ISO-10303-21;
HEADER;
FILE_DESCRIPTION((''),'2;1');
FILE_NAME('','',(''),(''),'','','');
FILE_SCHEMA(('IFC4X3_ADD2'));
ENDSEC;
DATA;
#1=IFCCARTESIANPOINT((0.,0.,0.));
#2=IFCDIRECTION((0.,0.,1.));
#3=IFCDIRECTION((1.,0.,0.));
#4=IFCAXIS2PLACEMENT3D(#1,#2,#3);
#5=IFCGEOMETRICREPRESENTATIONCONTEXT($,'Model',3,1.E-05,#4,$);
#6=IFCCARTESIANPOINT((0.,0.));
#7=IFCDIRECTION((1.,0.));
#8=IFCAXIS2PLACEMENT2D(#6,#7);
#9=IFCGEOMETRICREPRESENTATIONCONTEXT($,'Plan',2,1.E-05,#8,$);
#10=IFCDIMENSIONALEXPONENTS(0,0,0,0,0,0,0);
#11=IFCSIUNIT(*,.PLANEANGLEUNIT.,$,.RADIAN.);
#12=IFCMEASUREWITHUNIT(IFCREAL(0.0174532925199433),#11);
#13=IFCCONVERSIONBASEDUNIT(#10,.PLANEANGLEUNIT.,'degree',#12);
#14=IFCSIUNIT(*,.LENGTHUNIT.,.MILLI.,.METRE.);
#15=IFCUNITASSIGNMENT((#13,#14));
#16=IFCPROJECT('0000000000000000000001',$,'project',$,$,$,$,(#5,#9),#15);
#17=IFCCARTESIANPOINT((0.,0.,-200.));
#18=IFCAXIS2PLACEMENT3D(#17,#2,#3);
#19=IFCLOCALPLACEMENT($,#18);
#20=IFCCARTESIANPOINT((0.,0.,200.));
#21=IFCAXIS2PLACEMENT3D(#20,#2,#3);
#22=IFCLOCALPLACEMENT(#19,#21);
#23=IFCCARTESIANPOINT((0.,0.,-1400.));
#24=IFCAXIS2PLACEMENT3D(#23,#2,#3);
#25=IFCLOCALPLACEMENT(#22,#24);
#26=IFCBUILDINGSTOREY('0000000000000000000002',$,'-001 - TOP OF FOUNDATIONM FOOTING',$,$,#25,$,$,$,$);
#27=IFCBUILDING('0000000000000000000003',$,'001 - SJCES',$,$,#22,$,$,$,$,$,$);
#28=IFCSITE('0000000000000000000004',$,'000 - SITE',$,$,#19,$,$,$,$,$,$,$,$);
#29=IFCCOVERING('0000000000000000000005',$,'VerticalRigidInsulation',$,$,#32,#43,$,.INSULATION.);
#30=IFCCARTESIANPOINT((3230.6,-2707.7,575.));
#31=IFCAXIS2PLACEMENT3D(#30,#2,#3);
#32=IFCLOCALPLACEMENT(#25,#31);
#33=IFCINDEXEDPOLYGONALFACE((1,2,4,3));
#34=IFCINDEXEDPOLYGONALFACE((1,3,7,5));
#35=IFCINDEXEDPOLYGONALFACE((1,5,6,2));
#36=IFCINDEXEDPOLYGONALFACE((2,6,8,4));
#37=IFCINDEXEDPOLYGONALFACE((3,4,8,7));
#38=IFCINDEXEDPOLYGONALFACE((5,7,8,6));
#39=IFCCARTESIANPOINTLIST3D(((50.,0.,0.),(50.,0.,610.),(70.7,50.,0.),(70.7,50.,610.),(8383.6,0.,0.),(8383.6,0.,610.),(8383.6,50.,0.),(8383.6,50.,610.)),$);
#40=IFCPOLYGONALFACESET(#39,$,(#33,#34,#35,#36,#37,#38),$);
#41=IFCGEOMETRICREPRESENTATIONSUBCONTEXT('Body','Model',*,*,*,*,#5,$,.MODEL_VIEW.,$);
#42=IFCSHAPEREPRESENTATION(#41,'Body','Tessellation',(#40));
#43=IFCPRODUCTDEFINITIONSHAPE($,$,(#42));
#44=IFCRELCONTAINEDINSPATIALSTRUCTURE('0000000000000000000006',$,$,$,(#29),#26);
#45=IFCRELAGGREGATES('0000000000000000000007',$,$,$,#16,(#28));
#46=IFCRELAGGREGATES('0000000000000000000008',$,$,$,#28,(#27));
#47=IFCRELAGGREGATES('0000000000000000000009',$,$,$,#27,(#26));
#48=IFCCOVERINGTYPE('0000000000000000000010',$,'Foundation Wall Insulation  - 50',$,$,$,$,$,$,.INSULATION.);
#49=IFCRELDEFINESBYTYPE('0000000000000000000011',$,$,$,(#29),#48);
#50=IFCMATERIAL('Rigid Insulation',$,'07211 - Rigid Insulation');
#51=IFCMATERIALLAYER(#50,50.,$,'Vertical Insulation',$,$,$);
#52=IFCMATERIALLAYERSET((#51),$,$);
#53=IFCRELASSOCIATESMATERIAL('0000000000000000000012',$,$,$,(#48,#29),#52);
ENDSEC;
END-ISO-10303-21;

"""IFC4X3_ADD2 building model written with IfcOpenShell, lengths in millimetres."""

from ifc_helpers import new_model, entity, si_unit, converted_unit, frame, origin_with_axes, origin_2d_with_axis, place, context, subcontext, project, spatial, indexed_curve, outline, extrude, clip, halfspace, material, layer, layer_set, layer_usage, type_object, element, save


model = new_model("IFC4X3_ADD2")

# Units and contexts
model_context = context("Model", 3, precision=1e-05, world=origin_with_axes())
plan_context = context("Plan", 2, precision=1e-05, world=origin_2d_with_axis())
body_context = subcontext(model_context, "Body", "Model", "MODEL_VIEW")
ifc_project = project(units=[converted_unit("PLANEANGLEUNIT", "degree", entity("IfcReal", 0.0174532925199433), si_unit("PLANEANGLEUNIT", "RADIAN"), dimensions=[0, 0, 0, 0, 0, 0, 0]), si_unit("LENGTHUNIT", "METRE", prefix="MILLI")], contexts=[model_context, plan_context])

# Site, building, storey
site_placement = place(None, frame((0.0, 0.0, -200.0), z_axis=(0.0, 0.0, 1.0), x_axis=(1.0, 0.0, 0.0)))
site = spatial("IfcSite", under=ifc_project, at=site_placement, Name="000 - SITE")
building_placement = place(site_placement, frame((0.0, 0.0, 200.0), z_axis=(0.0, 0.0, 1.0), x_axis=(1.0, 0.0, 0.0)))
building = spatial("IfcBuilding", under=site, at=building_placement, Name="001 - SJCES")
storey_placement = place(building_placement, frame((0.0, 0.0, -1400.0), z_axis=(0.0, 0.0, 1.0), x_axis=(1.0, 0.0, 0.0)))
storey = spatial("IfcBuildingStorey", under=building, at=storey_placement, Name="-001 - TOP OF FOUNDATIONM FOOTING")

# Covering
ifc_material_1 = material(Name="Rigid Insulation", Category="07211 - Rigid Insulation")
ifc_layer_1 = layer(ifc_material_1, 50.0, Name="Vertical Insulation")
ifc_layer_set_1 = layer_set([ifc_layer_1])
ifc_layer_usage_1 = layer_usage(ifc_layer_set_1, "AXIS2", "POSITIVE", 0.0)
covering_type = type_object("IfcCoveringType", Name="Foundation Wall Insulation  - 50", PredefinedType="INSULATION", material=ifc_layer_set_1)
covering_1_placement = place(storey_placement, frame((3230.6, -2707.7, 575.0), z_axis=(0.0, 0.0, 1.0), x_axis=(1.0, 0.0, 0.0)))
element("IfcCovering", 1, at=covering_1_placement, inside=storey, type_object=covering_type, material=ifc_layer_usage_1, Name="VerticalRigidInsulation", PredefinedType="INSULATION", context=body_context, shape_type="Clipping", body=[
    clip(extrude(outline(indexed_curve([(0.0, 0.0), (0.0, 50.0), (8383.6, 50.0), (8383.6, 0.0), (0.0, 0.0)], self_intersect=False)), origin_with_axes(), (0.0, 0.0, 1.0), 610.0), halfspace(frame((50.0, 0.0, 825.0), z_axis=(-0.923881, 0.38268, 0.0), x_axis=(0.38268, 0.923881, 0.0)), False)),
])

save(model, "model.ifc")
